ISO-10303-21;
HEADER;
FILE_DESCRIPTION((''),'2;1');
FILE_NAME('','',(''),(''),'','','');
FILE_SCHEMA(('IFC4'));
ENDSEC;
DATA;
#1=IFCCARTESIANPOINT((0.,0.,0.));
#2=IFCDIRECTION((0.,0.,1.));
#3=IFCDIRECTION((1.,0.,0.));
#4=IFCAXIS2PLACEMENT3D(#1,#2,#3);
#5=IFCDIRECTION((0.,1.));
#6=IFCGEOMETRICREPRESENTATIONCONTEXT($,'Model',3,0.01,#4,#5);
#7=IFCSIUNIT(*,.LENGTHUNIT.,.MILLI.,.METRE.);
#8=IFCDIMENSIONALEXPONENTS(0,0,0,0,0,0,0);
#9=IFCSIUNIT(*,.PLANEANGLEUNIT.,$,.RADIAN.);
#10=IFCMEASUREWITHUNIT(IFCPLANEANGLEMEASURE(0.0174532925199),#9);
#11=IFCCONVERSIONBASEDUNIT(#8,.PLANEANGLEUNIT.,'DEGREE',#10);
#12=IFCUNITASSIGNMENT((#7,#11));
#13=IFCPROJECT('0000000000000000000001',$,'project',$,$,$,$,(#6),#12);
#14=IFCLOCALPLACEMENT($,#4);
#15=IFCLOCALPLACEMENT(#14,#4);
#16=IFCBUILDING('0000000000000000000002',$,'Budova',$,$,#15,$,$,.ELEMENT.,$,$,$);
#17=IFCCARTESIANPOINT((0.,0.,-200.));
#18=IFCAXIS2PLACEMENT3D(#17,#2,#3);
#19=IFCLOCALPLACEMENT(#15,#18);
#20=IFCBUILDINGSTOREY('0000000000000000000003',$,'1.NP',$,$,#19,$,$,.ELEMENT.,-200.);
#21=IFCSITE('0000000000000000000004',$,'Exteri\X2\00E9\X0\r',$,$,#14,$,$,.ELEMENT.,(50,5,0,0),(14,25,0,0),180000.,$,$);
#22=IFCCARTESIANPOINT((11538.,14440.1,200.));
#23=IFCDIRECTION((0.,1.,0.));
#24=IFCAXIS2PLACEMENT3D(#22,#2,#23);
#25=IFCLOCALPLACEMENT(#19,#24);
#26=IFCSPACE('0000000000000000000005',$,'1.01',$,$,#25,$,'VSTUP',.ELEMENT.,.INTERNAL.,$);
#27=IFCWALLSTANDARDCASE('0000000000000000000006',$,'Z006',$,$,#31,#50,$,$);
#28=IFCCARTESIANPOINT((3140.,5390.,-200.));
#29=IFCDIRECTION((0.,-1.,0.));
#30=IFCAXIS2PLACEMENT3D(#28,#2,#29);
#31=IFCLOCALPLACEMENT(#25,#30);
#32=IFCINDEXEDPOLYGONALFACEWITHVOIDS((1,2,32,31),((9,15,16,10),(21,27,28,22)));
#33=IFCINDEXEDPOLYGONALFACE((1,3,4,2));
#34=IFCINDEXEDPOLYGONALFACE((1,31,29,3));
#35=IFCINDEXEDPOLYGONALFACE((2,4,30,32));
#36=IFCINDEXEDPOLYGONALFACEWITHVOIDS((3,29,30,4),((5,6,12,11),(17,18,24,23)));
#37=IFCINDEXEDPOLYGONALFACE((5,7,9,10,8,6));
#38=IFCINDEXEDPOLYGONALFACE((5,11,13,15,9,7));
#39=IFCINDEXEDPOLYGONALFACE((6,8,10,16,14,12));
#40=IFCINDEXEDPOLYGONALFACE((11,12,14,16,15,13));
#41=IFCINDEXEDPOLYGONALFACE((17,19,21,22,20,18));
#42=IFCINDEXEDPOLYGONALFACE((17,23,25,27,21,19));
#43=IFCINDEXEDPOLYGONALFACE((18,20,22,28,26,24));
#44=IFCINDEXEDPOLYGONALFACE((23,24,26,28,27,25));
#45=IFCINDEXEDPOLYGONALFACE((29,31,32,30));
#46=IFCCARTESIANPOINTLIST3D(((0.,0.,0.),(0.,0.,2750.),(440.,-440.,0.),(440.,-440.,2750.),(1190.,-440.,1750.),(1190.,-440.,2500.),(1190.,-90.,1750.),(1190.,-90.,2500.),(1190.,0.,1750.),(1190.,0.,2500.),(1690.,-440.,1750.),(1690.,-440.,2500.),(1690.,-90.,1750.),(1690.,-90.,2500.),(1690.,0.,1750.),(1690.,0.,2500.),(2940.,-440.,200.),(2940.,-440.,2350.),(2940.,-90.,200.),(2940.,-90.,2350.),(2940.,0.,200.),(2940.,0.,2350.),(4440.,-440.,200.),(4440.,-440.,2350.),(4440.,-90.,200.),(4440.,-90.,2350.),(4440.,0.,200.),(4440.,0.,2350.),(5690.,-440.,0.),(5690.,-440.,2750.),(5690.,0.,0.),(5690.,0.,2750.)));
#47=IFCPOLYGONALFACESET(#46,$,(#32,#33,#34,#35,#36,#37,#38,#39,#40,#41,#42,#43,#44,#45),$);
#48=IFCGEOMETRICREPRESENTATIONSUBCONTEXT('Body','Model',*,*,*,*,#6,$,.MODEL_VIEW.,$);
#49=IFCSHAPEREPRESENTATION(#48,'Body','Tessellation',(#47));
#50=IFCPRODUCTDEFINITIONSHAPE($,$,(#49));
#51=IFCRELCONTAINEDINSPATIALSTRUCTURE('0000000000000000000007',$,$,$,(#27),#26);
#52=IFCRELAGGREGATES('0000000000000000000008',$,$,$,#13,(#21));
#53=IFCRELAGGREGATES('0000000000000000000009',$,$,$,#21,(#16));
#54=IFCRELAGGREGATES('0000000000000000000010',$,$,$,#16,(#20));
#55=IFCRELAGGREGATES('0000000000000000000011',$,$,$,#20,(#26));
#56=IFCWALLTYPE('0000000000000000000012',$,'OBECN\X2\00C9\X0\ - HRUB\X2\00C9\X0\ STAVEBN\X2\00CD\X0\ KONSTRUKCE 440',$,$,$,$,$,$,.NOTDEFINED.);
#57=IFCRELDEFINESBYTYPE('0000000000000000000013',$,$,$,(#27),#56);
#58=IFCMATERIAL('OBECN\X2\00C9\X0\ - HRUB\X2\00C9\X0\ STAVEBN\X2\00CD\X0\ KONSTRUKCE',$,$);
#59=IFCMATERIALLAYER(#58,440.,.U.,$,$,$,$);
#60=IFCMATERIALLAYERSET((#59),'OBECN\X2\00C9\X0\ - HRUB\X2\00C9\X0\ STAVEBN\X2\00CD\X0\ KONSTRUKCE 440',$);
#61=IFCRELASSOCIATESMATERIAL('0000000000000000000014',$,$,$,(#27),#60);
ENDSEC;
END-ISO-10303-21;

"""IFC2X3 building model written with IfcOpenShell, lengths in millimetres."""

from ifc_helpers import new_model, entity, si_unit, converted_unit, direction, frame, origin_with_axes, origin_2d_with_axis, place, context, subcontext, project, spatial, polyline, rectangle, outline, extrude, material, layer, layer_set, layer_usage, type_object, element, save


model = new_model("IFC2X3")

# Units and contexts
model_context = context("Model", 3, precision=0.01, world=origin_with_axes(), true_north=direction((0.0, 1.0)))
body_context = subcontext(model_context, "Body", "Model", "MODEL_VIEW")
ifc_project = project(units=[si_unit("LENGTHUNIT", "METRE", prefix="MILLI"), converted_unit("PLANEANGLEUNIT", "DEGREE", entity("IfcPlaneAngleMeasure", 0.0174532925199), si_unit("PLANEANGLEUNIT", "RADIAN"), dimensions=[0, 0, 0, 0, 0, 0, 0])], contexts=[model_context])

# Site, building, storey
site_placement = place(None, origin_with_axes())
site = spatial("IfcSite", under=ifc_project, at=site_placement, Name="Exteriér", CompositionType="ELEMENT", RefLatitude=(50, 5, 0, 0), RefLongitude=(14, 25, 0, 0), RefElevation=180000.0)
building_placement = place(site_placement, origin_with_axes())
building = spatial("IfcBuilding", under=site, at=building_placement, Name="Budova", CompositionType="ELEMENT")
storey_placement = place(building_placement, frame((0.0, 0.0, -200.0), z_axis=(0.0, 0.0, 1.0), x_axis=(1.0, 0.0, 0.0)))
storey = spatial("IfcBuildingStorey", under=building, at=storey_placement, Name="1.NP", CompositionType="ELEMENT", Elevation=-200.0)

# Shared definitions
ifc_material_1 = material(Name="OBECNÉ - HRUBÉ STAVEBNÍ KONSTRUKCE")
ifc_layer_1 = layer(ifc_material_1, 440.0, ventilated="UNKNOWN")
ifc_layer_set_1 = layer_set([ifc_layer_1], Name="OBECNÉ - HRUBÉ STAVEBNÍ KONSTRUKCE 440")
wall_type_1 = type_object("IfcWallType", Name="OBECNÉ - HRUBÉ STAVEBNÍ KONSTRUKCE 440", PredefinedType="NOTDEFINED")

# Shared definitions
space_placement = place(storey_placement, frame((11538.0, 14440.1, 200.0), z_axis=(0.0, 0.0, 1.0), x_axis=(0.0, 1.0, 0.0)))
space = spatial("IfcSpace", under=storey, at=space_placement, Name="1.01", LongName="VSTUP", CompositionType="ELEMENT", InteriorOrExteriorSpace="INTERNAL")

# Wall, openings
ifc_layer_usage_1 = layer_usage(ifc_layer_set_1, "AXIS2", "NEGATIVE", 0.0)
wall_1_placement = place(space_placement, frame((3140.0, 5390.0, -200.0), z_axis=(0.0, 0.0, 1.0), x_axis=(0.0, -1.0, 0.0)))
wall_1 = element("IfcWallStandardCase", 1, at=wall_1_placement, inside=space, type_object=wall_type_1, material=ifc_layer_usage_1, Name="Z006", context=body_context, shape_type="SweptSolid", body=[
    extrude(outline(polyline([(440.0, -440.0), (5690.0, -440.0), (5690.0, 0.0), (0.0, 0.0), (440.0, -440.0)])), origin_with_axes(), (0.0, 0.0, 1.0), 2750.0),
])
opening_1_placement = place(wall_1_placement, frame((1440.0, 0.0, 1750.0), z_axis=(0.0, 0.0, 1.0), x_axis=(1.0, 0.0, 0.0)))
element("IfcOpeningElement", 2, at=opening_1_placement, cuts=wall_1, context=body_context, shape_type="SweptSolid", body=[
    extrude(rectangle(XDim=500.0, YDim=750.0, at=origin_2d_with_axis()), frame((0.0, -90.0, 375.0), z_axis=(0.0, -1.0, 0.0), x_axis=(1.0, 0.0, 0.0)), (0.0, 0.0, 1.0), 790.0),
    extrude(rectangle(XDim=500.0, YDim=750.0, at=origin_2d_with_axis()), frame((0.0, -90.0, 375.0), z_axis=(0.0, 1.0, 0.0), x_axis=(1.0, 0.0, 0.0)), (0.0, 0.0, 1.0), 530.0),
])
opening_2_placement = place(wall_1_placement, frame((3690.0, 0.0, 200.0), z_axis=(0.0, 0.0, 1.0), x_axis=(1.0, 0.0, 0.0)))
element("IfcOpeningElement", 3, at=opening_2_placement, cuts=wall_1, context=body_context, shape_type="SweptSolid", body=[
    extrude(rectangle(XDim=1500.0, YDim=2150.0, at=origin_2d_with_axis()), frame((0.0, -90.0, 1075.0), z_axis=(0.0, 1.0, 0.0), x_axis=(-1.0, 0.0, 0.0)), (0.0, 0.0, -1.0), 790.0),
    extrude(rectangle(XDim=1500.0, YDim=2150.0, at=origin_2d_with_axis()), frame((0.0, -90.0, 1075.0), z_axis=(0.0, -1.0, 0.0), x_axis=(-1.0, 0.0, 0.0)), (0.0, 0.0, -1.0), 530.0),
])

save(model, "model.ifc")
